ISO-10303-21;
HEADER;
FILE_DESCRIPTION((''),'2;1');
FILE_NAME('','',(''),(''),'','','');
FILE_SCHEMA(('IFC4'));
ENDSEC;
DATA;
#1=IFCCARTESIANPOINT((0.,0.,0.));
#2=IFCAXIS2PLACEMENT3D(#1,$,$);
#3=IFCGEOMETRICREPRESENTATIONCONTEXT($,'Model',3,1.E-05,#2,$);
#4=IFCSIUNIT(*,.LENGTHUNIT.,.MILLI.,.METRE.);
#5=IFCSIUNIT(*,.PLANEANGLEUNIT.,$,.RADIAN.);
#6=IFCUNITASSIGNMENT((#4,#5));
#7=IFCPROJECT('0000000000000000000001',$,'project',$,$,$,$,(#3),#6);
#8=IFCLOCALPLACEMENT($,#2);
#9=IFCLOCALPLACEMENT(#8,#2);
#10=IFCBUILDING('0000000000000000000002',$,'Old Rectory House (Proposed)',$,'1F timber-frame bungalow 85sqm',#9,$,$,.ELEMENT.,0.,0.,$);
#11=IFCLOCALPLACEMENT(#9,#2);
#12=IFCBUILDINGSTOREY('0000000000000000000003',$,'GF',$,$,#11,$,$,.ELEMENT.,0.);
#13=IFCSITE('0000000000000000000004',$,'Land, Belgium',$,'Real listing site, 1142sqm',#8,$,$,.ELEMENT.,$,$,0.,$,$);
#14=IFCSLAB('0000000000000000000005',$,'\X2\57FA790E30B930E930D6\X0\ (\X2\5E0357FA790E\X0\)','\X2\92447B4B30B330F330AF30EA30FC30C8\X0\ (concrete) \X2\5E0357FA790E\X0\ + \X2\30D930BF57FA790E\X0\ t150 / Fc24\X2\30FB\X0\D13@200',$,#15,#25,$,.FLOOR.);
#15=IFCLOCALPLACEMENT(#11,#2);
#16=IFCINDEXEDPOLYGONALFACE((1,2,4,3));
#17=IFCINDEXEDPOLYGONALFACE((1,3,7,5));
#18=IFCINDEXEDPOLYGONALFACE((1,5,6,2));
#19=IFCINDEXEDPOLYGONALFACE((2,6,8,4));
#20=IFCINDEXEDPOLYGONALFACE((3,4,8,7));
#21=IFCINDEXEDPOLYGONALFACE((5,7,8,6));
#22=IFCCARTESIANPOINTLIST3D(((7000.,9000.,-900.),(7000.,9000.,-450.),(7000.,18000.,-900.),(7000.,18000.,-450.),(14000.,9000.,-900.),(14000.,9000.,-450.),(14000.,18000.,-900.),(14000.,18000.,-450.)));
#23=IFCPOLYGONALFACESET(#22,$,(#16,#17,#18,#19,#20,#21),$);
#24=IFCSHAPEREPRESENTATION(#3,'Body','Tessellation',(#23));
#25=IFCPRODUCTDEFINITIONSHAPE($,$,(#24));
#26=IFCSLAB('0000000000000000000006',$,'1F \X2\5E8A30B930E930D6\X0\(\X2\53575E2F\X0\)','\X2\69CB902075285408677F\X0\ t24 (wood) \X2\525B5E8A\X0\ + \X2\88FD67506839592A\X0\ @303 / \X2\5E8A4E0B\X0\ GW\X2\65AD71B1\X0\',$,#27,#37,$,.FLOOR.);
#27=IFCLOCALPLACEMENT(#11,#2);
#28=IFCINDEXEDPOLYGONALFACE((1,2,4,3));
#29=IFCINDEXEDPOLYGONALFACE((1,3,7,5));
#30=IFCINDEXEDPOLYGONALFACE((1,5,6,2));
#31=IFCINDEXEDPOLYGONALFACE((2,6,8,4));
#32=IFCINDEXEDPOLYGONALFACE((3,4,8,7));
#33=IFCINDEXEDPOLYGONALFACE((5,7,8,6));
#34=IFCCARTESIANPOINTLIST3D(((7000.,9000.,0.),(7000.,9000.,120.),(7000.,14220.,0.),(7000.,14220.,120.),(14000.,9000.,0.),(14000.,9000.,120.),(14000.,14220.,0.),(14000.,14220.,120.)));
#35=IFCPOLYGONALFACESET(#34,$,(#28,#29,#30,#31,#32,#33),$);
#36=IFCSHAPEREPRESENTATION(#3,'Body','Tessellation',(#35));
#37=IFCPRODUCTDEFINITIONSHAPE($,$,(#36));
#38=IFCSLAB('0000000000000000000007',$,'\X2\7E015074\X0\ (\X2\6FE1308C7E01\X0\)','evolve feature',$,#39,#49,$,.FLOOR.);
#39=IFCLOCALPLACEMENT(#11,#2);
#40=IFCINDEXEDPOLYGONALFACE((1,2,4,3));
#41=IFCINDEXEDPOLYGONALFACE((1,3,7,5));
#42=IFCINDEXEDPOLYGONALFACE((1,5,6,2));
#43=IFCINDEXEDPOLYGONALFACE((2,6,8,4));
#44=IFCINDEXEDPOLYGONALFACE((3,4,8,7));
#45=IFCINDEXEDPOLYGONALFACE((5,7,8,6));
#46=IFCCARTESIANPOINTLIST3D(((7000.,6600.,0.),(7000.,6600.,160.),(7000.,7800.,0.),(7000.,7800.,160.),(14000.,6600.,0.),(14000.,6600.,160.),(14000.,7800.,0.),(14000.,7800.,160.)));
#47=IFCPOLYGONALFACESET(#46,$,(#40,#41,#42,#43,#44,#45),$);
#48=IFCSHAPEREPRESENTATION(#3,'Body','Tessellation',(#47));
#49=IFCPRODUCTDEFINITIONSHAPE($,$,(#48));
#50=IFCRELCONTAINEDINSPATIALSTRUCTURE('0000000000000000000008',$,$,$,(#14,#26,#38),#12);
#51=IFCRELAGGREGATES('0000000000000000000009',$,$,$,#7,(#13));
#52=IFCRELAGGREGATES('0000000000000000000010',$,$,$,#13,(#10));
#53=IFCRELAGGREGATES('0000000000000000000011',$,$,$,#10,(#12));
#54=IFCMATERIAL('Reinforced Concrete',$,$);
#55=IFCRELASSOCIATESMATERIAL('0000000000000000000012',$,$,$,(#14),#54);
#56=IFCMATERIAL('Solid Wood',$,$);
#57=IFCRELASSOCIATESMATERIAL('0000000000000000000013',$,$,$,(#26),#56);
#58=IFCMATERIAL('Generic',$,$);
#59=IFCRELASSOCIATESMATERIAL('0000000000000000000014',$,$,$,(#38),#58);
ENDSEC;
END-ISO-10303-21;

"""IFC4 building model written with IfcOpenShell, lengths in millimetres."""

from ifc_helpers import new_model, si_unit, frame, frame_2d, origin, place, context, project, spatial, rectangle, extrude, material, element, save


model = new_model("IFC4")

# Units and contexts
model_context = context("Model", 3, precision=1e-05, world=origin())
ifc_project = project(units=[si_unit("LENGTHUNIT", "METRE", prefix="MILLI"), si_unit("PLANEANGLEUNIT", "RADIAN")], contexts=[model_context])

# Site, building, storey
site_placement = place(None, origin())
site = spatial("IfcSite", under=ifc_project, at=site_placement, Name="Land, Belgium", ObjectType="Real listing site, 1142sqm", CompositionType="ELEMENT", RefElevation=0.0)
building_placement = place(site_placement, origin())
building = spatial("IfcBuilding", under=site, at=building_placement, Name="Old Rectory House (Proposed)", ObjectType="1F timber-frame bungalow 85sqm", CompositionType="ELEMENT", ElevationOfRefHeight=0.0, ElevationOfTerrain=0.0)
storey_placement = place(building_placement, origin())
storey = spatial("IfcBuildingStorey", under=building, at=storey_placement, Name="GF", CompositionType="ELEMENT", Elevation=0.0)

# Slabs
ifc_material_1 = material(Name="Reinforced Concrete")
slab_1_placement = place(storey_placement, frame((3500.0, 4500.0, -450.0)))
element("IfcSlab", 1, at=slab_1_placement, inside=storey, material=ifc_material_1, Name="基礎スラブ (布基礎)", Description="鉄筋コンクリート (concrete) 布基礎 + ベタ基礎 t150 / Fc24・D13@200", PredefinedType="FLOOR", context=model_context, shape_type="SweptSolid", body=[
    extrude(rectangle(XDim=7000.0, YDim=9000.0, at=frame_2d((3500.0, 4500.0))), frame((3500.0, 4500.0, -450.0)), (0.0, 0.0, 1.0), 450.0),
])
ifc_material_2 = material(Name="Solid Wood")
slab_2_placement = place(storey_placement, frame((3500.0, 4500.0, 0.0)))
element("IfcSlab", 2, at=slab_2_placement, inside=storey, material=ifc_material_2, Name="1F 床スラブ(南帯)", Description="構造用合板 t24 (wood) 剛床 + 製材根太 @303 / 床下 GW断熱", PredefinedType="FLOOR", context=model_context, shape_type="SweptSolid", body=[
    extrude(rectangle(XDim=7000.0, YDim=5220.0, at=frame_2d((3500.0, 2610.0))), frame((3500.0, 4500.0, 0.0)), (0.0, 0.0, 1.0), 120.0),
])
ifc_material_3 = material(Name="Generic")
slab_3_placement = place(storey_placement, frame((3500.0, 3300.0, 0.0)))
element("IfcSlab", 3, at=slab_3_placement, inside=storey, material=ifc_material_3, Name="縁側 (濡れ縁)", Description="evolve feature", PredefinedType="FLOOR", context=model_context, shape_type="SweptSolid", body=[
    extrude(rectangle(XDim=7000.0, YDim=1200.0, at=frame_2d((3500.0, 600.0))), frame((3500.0, 3300.0, 0.0)), (0.0, 0.0, 1.0), 160.0),
])

save(model, "model.ifc")
